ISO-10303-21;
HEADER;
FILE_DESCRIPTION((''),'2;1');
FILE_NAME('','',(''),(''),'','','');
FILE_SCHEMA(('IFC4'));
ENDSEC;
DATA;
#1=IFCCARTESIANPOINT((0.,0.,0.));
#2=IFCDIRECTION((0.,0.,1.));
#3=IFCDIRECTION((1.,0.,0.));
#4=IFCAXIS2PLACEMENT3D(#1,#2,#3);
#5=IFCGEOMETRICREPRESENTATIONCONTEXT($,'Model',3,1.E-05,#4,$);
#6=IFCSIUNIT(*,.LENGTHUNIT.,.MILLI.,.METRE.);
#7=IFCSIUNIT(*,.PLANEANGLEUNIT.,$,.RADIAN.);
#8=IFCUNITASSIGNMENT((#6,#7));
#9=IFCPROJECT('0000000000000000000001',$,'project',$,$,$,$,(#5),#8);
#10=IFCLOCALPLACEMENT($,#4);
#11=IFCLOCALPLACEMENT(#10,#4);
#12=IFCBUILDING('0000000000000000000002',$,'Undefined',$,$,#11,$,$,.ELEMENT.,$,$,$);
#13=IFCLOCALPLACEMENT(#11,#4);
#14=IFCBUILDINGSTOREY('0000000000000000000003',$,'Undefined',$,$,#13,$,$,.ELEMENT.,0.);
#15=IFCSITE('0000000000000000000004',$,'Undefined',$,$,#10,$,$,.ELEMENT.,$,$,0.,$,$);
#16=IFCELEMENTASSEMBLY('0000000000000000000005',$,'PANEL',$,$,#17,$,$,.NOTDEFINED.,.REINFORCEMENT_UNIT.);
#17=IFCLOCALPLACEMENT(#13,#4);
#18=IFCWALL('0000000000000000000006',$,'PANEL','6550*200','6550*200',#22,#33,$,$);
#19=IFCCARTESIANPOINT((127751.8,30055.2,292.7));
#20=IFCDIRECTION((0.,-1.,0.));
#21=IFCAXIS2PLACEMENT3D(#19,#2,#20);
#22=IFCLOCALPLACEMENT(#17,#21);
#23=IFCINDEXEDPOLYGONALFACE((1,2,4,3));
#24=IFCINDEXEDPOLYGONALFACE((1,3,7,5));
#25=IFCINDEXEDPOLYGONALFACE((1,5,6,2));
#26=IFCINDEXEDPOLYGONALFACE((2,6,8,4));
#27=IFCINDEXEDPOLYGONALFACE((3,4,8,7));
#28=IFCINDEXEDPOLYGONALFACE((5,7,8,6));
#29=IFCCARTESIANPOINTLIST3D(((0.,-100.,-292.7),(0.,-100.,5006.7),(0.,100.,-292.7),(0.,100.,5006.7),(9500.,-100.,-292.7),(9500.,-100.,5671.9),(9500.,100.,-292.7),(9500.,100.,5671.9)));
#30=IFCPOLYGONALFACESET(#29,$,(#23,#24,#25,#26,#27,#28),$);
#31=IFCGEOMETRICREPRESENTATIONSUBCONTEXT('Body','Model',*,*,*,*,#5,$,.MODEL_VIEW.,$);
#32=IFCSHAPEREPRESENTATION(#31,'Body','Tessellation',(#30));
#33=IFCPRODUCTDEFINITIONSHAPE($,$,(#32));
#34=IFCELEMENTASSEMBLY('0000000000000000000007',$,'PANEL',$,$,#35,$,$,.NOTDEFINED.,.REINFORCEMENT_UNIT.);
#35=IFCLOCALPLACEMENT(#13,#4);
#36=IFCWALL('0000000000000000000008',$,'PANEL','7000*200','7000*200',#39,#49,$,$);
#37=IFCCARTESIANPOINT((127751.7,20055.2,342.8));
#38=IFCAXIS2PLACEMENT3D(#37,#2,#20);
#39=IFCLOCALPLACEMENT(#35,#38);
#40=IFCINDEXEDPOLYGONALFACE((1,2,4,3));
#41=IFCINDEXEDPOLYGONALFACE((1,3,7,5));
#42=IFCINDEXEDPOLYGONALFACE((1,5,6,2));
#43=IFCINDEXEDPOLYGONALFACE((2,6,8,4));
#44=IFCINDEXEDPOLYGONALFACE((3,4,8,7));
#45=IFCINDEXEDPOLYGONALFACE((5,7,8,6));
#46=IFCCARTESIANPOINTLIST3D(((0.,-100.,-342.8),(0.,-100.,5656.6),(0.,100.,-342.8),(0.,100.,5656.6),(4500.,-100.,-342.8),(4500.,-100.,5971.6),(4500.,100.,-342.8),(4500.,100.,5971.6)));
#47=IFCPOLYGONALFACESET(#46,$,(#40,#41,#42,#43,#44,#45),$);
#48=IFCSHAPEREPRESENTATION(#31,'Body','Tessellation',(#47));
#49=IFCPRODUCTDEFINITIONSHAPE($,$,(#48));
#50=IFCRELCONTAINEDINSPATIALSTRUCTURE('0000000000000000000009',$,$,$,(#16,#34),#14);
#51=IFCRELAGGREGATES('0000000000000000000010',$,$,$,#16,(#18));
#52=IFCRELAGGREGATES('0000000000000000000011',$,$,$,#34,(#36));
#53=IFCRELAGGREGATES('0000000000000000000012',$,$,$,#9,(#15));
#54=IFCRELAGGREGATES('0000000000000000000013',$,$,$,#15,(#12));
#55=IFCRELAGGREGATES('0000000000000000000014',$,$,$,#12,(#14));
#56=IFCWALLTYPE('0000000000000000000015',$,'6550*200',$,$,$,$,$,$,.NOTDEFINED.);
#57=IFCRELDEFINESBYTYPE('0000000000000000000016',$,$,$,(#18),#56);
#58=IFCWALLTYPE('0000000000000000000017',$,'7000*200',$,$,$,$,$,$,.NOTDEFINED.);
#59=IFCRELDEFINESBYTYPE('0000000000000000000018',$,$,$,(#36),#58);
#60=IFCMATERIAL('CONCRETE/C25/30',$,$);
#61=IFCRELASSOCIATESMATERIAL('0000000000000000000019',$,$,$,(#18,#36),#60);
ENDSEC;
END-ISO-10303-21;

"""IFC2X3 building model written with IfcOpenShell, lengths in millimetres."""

from ifc_helpers import new_model, si_unit, frame, frame_2d, origin_with_axes, place, context, subcontext, project, spatial, rectangle, extrude, clip, halfspace, material, type_object, element, aggregate, save


model = new_model("IFC2X3")

# Units and contexts
model_context = context("Model", 3, precision=1e-05, world=origin_with_axes())
body_context = subcontext(model_context, "Body", "Model", "MODEL_VIEW")
ifc_project = project(units=[si_unit("LENGTHUNIT", "METRE", prefix="MILLI"), si_unit("PLANEANGLEUNIT", "RADIAN")], contexts=[model_context])

# Site, building, storey
site_placement = place(None, origin_with_axes())
site = spatial("IfcSite", under=ifc_project, at=site_placement, Name="Undefined", CompositionType="ELEMENT", RefElevation=0.0)
building_placement = place(site_placement, origin_with_axes())
building = spatial("IfcBuilding", under=site, at=building_placement, Name="Undefined", CompositionType="ELEMENT")
storey_placement = place(building_placement, origin_with_axes())
storey = spatial("IfcBuildingStorey", under=building, at=storey_placement, Name="Undefined", CompositionType="ELEMENT", Elevation=0.0)

# Shared definitions
ifc_material_1 = material(Name="CONCRETE/C25/30")

# Element assemblies, walls
assembly_1_placement = place(storey_placement, origin_with_axes())
assembly_1 = element("IfcElementAssembly", 1, at=assembly_1_placement, inside=storey, Name="PANEL", AssemblyPlace="NOTDEFINED", PredefinedType="REINFORCEMENT_UNIT")
wall_type_1 = type_object("IfcWallType", Name="6550*200", PredefinedType="NOTDEFINED")
wall_1_placement = place(assembly_1_placement, frame((127751.8, 30055.2, 292.7), z_axis=(0.0, 0.0, 1.0), x_axis=(0.0, -1.0, 0.0)))
wall_1 = element("IfcWall", 2, at=wall_1_placement, type_object=wall_type_1, material=ifc_material_1, Name="PANEL", Description="6550*200", ObjectType="6550*200", context=body_context, shape_type="Clipping", body=[
    clip(extrude(rectangle(XDim=9500.0, YDim=200.0, at=frame_2d((0.0, 4750.0), x_axis=(0.0, -1.0))), frame((0.0, 0.0, -292.7), z_axis=(0.0, 0.0, 1.0), x_axis=(0.0, -1.0, 0.0)), (0.0, 0.0, 1.0), 6550.0), halfspace(frame((9500.0, 100.0, 5671.9), z_axis=(-0.069842, 0.0, 0.997558), x_axis=(0.0, -1.0, 0.0)), False)),
])
aggregate(assembly_1, [wall_1])
assembly_2_placement = place(storey_placement, origin_with_axes())
assembly_2 = element("IfcElementAssembly", 3, at=assembly_2_placement, inside=storey, Name="PANEL", AssemblyPlace="NOTDEFINED", PredefinedType="REINFORCEMENT_UNIT")
wall_type_2 = type_object("IfcWallType", Name="7000*200", PredefinedType="NOTDEFINED")
wall_2_placement = place(assembly_2_placement, frame((127751.7, 20055.2, 342.8), z_axis=(0.0, 0.0, 1.0), x_axis=(0.0, -1.0, 0.0)))
wall_2 = element("IfcWall", 4, at=wall_2_placement, type_object=wall_type_2, material=ifc_material_1, Name="PANEL", Description="7000*200", ObjectType="7000*200", context=body_context, shape_type="Clipping", body=[
    clip(extrude(rectangle(XDim=4500.0, YDim=200.0, at=frame_2d((0.0, 2250.0), x_axis=(0.0, -1.0))), frame((0.0, 0.0, -342.8), z_axis=(0.0, 0.0, 1.0), x_axis=(0.0, -1.0, 0.0)), (0.0, 0.0, 1.0), 7000.0), halfspace(frame((4500.0, 100.0, 5971.6), z_axis=(-0.069829, 0.0, 0.997559), x_axis=(0.0, -1.0, 0.0)), False)),
])
aggregate(assembly_2, [wall_2])

save(model, "model.ifc")
